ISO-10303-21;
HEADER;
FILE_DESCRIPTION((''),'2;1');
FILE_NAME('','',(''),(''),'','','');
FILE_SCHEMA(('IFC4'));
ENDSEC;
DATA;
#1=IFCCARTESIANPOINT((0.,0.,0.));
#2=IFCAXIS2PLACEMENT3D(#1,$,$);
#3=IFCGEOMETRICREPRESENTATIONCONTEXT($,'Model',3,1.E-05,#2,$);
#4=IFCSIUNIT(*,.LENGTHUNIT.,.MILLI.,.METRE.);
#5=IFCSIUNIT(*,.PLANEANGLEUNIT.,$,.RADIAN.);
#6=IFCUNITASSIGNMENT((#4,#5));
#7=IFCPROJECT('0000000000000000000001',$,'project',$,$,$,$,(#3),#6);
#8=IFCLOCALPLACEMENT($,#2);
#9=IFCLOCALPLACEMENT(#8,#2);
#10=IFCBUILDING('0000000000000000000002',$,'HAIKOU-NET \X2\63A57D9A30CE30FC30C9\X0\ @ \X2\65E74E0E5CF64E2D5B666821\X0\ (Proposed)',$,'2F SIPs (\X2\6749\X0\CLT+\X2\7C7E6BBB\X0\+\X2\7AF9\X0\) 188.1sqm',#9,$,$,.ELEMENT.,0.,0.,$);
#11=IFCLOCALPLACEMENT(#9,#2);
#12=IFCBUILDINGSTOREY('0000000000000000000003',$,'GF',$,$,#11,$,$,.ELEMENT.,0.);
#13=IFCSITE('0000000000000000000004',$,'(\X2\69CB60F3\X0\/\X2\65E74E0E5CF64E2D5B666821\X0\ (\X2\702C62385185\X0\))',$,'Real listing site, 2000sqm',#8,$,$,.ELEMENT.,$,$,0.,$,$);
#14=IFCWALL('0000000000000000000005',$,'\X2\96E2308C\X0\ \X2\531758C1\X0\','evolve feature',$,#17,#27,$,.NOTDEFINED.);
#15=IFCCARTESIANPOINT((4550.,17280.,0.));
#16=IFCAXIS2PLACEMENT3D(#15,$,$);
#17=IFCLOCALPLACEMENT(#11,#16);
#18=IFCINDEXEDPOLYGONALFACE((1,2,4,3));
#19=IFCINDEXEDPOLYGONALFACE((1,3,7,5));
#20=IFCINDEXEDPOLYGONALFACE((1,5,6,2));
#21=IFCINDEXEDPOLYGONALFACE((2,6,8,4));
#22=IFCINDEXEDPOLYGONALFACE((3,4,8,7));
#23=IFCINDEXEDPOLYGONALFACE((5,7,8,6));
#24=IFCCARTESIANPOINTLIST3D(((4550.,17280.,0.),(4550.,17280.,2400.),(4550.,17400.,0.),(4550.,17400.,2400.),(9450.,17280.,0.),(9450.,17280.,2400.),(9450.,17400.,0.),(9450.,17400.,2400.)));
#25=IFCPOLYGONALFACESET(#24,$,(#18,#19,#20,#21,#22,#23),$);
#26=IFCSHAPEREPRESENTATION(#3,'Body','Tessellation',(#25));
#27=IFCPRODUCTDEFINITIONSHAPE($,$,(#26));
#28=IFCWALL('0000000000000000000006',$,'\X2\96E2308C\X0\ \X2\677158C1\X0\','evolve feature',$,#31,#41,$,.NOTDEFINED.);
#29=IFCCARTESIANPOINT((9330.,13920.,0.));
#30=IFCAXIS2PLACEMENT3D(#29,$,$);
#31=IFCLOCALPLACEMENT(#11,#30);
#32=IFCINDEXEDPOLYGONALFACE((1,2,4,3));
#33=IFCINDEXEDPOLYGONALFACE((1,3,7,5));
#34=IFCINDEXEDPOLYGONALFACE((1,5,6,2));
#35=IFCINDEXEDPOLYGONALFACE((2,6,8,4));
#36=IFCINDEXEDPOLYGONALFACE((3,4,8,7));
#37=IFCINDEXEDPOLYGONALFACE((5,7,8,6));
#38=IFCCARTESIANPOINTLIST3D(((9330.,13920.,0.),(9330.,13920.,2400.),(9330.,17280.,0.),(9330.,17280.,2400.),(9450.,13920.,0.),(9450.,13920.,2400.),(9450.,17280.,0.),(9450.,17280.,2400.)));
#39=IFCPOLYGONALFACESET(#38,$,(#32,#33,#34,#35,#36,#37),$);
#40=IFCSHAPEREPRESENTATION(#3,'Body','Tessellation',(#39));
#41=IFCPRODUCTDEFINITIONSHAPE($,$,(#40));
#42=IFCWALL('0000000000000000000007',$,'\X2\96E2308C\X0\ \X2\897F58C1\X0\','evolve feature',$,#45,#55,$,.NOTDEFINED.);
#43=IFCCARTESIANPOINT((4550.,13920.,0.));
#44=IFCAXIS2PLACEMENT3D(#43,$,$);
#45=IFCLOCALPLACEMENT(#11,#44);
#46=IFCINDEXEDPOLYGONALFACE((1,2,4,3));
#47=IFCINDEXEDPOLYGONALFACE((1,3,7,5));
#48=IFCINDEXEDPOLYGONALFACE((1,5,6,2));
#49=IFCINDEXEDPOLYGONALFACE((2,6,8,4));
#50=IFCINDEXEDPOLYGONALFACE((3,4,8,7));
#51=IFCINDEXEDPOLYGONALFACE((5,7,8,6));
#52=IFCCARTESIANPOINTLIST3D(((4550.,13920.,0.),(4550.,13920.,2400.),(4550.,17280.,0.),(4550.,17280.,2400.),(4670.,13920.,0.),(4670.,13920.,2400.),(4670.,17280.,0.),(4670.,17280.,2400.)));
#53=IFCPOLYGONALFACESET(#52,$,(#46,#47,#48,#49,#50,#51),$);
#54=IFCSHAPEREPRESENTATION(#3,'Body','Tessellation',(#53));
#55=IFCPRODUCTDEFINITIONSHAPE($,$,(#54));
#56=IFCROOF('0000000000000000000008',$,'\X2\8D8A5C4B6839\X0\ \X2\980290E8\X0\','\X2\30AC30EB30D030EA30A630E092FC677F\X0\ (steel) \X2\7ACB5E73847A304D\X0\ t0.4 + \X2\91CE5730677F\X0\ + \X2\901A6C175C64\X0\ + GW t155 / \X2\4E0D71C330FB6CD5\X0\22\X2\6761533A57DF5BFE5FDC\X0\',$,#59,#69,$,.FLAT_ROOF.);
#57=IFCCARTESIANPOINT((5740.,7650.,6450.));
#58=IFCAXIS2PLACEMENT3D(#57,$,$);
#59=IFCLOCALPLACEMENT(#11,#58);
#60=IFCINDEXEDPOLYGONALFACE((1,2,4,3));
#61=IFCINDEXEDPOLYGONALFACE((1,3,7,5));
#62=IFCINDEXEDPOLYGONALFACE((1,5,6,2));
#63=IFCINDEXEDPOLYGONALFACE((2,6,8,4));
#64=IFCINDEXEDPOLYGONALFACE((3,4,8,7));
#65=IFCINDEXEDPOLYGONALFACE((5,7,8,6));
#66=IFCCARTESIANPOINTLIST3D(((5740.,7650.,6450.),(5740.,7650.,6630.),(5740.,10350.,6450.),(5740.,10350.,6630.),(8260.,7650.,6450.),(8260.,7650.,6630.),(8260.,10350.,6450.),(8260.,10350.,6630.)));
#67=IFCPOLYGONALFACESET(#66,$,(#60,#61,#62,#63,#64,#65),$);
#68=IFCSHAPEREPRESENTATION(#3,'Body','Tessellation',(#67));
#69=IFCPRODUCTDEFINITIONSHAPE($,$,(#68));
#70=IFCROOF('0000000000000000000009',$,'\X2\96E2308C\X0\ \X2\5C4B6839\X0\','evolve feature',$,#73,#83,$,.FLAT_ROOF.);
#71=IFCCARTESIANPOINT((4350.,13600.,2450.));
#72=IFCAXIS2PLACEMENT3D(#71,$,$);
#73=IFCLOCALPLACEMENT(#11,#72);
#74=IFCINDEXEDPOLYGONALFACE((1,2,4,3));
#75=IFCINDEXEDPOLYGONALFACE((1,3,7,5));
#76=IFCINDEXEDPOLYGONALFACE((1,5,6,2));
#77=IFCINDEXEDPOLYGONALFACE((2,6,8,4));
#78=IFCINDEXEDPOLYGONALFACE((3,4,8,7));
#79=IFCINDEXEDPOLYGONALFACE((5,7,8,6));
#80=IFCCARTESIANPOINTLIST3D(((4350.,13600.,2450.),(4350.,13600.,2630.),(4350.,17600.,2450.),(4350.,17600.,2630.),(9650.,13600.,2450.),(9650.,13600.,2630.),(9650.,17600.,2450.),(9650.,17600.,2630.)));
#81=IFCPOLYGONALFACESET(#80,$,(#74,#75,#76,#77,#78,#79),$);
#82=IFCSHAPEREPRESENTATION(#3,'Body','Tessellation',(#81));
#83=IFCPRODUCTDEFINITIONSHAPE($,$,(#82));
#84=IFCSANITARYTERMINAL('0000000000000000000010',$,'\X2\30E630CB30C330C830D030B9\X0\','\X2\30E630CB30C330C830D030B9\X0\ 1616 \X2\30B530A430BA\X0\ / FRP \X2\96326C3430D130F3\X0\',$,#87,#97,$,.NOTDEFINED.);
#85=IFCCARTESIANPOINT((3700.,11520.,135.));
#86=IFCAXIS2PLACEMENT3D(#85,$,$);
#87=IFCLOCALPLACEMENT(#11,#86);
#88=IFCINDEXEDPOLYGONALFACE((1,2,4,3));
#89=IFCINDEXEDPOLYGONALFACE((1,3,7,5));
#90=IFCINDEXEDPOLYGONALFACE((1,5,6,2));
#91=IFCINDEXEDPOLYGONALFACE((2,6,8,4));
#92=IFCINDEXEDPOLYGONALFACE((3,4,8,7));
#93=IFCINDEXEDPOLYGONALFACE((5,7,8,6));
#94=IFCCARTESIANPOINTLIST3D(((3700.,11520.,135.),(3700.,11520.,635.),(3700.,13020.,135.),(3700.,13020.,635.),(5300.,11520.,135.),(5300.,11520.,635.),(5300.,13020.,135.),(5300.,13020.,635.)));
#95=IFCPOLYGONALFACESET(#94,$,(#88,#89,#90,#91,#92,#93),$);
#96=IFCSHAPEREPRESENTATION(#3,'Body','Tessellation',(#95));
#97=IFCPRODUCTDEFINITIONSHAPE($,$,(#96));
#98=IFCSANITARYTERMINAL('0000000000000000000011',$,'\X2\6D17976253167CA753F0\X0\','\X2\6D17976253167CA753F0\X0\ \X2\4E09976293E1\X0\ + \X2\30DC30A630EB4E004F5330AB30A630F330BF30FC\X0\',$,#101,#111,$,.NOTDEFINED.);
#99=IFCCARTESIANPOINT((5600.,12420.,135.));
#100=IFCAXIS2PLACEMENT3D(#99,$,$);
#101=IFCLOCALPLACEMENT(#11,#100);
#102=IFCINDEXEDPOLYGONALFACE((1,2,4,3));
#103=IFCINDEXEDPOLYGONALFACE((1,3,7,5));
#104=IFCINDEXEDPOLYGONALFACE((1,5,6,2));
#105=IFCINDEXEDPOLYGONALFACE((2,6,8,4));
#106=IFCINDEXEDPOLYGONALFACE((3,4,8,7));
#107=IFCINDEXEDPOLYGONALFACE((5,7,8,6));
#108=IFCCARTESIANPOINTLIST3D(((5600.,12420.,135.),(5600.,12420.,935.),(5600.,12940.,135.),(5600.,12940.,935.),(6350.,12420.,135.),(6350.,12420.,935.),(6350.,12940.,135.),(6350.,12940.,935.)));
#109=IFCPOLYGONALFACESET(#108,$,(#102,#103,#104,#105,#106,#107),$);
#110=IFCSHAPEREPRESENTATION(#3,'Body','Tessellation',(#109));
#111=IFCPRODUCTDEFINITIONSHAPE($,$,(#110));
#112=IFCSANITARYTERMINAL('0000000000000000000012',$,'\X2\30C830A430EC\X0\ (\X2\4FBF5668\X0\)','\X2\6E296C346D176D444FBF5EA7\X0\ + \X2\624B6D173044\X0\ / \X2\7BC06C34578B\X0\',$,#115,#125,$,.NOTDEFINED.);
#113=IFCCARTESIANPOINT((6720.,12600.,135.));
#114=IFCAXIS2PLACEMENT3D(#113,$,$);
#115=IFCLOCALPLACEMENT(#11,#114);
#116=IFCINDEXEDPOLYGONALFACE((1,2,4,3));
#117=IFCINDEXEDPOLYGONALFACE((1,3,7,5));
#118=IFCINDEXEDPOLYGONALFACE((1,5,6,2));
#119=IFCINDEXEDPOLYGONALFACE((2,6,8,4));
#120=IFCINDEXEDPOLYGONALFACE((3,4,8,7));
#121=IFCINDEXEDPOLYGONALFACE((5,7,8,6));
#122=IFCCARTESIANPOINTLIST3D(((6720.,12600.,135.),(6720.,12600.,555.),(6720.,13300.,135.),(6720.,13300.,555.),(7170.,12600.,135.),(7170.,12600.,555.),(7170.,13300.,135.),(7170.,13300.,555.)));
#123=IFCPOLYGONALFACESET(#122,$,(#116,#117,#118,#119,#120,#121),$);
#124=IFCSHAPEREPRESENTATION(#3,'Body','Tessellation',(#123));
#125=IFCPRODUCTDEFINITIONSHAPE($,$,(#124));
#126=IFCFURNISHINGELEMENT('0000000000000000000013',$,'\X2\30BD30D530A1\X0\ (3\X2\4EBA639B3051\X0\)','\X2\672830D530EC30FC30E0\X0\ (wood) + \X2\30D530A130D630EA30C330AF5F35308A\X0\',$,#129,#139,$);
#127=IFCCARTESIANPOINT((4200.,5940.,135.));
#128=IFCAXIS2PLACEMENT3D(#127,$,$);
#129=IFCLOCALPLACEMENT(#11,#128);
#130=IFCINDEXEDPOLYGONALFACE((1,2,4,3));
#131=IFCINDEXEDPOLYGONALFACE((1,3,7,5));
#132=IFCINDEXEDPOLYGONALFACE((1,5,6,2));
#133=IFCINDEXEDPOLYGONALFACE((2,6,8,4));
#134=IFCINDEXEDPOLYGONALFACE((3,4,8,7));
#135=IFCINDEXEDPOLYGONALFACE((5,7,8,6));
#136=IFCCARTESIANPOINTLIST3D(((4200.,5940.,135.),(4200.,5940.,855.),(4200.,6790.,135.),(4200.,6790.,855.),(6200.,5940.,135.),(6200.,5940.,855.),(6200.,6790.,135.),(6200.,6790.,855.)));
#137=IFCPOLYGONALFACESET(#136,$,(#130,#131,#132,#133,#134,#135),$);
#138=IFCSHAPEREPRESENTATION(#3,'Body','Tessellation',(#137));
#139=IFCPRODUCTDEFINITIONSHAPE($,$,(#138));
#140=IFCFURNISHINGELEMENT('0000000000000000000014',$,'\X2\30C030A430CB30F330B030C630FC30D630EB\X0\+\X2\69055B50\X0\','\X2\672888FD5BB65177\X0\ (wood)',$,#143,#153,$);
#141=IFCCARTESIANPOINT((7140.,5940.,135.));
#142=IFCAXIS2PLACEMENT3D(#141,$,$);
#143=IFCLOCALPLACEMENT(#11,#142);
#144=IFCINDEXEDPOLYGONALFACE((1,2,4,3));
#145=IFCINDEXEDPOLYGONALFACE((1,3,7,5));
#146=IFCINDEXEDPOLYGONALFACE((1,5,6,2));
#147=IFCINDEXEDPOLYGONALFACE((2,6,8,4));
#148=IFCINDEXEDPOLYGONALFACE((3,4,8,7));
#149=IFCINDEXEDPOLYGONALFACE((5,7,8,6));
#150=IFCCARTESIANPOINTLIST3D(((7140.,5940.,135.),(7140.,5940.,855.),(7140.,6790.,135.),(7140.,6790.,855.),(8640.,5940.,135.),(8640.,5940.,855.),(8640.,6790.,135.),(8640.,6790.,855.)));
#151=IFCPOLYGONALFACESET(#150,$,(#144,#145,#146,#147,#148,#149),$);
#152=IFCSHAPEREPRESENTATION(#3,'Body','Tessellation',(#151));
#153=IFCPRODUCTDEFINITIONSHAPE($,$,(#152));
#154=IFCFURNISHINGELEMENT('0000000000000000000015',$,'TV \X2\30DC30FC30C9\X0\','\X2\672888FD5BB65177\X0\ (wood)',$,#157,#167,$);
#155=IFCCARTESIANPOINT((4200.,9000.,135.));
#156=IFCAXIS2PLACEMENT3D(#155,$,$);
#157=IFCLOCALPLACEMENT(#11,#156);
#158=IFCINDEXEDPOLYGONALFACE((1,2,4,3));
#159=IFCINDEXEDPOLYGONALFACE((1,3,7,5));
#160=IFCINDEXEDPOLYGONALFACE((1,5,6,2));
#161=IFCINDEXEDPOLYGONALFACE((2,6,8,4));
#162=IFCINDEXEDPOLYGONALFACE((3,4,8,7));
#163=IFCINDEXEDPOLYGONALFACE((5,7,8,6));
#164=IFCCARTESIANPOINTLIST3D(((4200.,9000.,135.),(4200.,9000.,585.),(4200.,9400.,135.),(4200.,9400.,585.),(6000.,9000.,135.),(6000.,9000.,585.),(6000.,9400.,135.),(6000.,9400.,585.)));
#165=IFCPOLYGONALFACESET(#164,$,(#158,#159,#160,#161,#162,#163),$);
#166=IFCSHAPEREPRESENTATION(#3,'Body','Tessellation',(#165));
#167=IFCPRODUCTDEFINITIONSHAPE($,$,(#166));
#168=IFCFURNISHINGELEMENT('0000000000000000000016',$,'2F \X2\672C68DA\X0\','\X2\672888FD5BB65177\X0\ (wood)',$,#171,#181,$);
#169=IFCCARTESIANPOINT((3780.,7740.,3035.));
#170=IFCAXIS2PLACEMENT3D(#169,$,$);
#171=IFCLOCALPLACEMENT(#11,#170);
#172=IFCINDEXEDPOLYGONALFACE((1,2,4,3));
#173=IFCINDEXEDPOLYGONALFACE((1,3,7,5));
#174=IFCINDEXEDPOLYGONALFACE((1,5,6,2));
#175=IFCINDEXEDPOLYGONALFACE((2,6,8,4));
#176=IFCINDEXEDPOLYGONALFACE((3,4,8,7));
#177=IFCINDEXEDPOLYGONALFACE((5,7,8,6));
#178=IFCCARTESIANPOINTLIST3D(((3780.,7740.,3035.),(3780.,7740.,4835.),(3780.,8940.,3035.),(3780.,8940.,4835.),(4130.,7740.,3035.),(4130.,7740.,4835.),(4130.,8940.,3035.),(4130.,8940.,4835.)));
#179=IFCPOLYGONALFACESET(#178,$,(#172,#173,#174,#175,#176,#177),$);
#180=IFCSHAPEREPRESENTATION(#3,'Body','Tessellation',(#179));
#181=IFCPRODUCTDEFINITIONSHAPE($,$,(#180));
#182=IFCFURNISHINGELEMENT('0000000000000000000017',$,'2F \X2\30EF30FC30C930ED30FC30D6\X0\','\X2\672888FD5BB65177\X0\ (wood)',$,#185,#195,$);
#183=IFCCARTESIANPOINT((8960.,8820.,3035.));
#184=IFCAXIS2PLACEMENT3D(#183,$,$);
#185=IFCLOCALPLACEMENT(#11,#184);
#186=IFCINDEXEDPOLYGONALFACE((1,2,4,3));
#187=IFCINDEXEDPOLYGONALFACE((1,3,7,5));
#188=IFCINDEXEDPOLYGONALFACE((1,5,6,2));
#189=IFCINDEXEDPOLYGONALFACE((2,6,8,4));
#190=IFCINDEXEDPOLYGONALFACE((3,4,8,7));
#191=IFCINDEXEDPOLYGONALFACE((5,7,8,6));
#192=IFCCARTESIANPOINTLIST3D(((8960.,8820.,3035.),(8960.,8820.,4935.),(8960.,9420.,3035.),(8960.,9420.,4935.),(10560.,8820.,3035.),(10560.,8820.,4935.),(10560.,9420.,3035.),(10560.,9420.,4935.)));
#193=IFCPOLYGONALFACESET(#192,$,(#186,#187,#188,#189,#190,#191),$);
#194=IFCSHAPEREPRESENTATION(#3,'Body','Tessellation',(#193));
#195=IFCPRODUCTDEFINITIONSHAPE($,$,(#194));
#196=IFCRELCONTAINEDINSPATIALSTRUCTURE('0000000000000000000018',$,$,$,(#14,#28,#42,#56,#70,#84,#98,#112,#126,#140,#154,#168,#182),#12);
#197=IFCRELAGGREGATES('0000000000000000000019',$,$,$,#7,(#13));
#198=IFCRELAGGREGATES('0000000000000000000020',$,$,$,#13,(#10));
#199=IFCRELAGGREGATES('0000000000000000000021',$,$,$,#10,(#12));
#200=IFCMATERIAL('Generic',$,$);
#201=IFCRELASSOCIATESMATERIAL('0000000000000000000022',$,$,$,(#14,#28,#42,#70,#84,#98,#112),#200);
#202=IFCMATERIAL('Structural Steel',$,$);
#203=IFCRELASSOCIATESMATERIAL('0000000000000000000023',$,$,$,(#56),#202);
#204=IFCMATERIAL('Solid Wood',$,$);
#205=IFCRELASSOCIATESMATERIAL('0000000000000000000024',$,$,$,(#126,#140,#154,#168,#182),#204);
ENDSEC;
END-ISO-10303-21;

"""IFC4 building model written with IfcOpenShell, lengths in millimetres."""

from ifc_helpers import new_model, si_unit, frame, frame_2d, origin, place, context, project, spatial, rectangle, extrude, material, element, save


model = new_model("IFC4")

# Units and contexts
model_context = context("Model", 3, precision=1e-05, world=origin())
ifc_project = project(units=[si_unit("LENGTHUNIT", "METRE", prefix="MILLI"), si_unit("PLANEANGLEUNIT", "RADIAN")], contexts=[model_context])

# Site, building, storey
site_placement = place(None, origin())
site = spatial("IfcSite", under=ifc_project, at=site_placement, Name="(構想/旧与島中学校 (瀬戸内))", ObjectType="Real listing site, 2000sqm", CompositionType="ELEMENT", RefElevation=0.0)
building_placement = place(site_placement, origin())
building = spatial("IfcBuilding", under=site, at=building_placement, Name="HAIKOU-NET 接続ノード @ 旧与島中学校 (Proposed)", ObjectType="2F SIPs (杉CLT+籾殻+竹) 188.1sqm", CompositionType="ELEMENT", ElevationOfRefHeight=0.0, ElevationOfTerrain=0.0)
storey_placement = place(building_placement, origin())
storey = spatial("IfcBuildingStorey", under=building, at=storey_placement, Name="GF", CompositionType="ELEMENT", Elevation=0.0)

# Shared definitions
ifc_material_1 = material(Name="Generic")

# Shared definitions
ifc_material_2 = material(Name="Solid Wood")

# Walls
wall_1_placement = place(storey_placement, frame((4550.0, 17280.0, 0.0)))
element("IfcWall", 1, at=wall_1_placement, inside=storey, material=ifc_material_1, Name="離れ 北壁", Description="evolve feature", PredefinedType="NOTDEFINED", context=model_context, shape_type="SweptSolid", body=[
    extrude(rectangle(XDim=4900.0, YDim=120.0, at=frame_2d((2450.0, 60.0))), frame((4550.0, 17280.0, 0.0)), (0.0, 0.0, 1.0), 2400.0),
])
wall_2_placement = place(storey_placement, frame((9330.0, 13920.0, 0.0)))
element("IfcWall", 2, at=wall_2_placement, inside=storey, material=ifc_material_1, Name="離れ 東壁", Description="evolve feature", PredefinedType="NOTDEFINED", context=model_context, shape_type="SweptSolid", body=[
    extrude(rectangle(XDim=120.0, YDim=3360.0, at=frame_2d((60.0, 1680.0))), frame((9330.0, 13920.0, 0.0)), (0.0, 0.0, 1.0), 2400.0),
])
wall_3_placement = place(storey_placement, frame((4550.0, 13920.0, 0.0)))
element("IfcWall", 3, at=wall_3_placement, inside=storey, material=ifc_material_1, Name="離れ 西壁", Description="evolve feature", PredefinedType="NOTDEFINED", context=model_context, shape_type="SweptSolid", body=[
    extrude(rectangle(XDim=120.0, YDim=3360.0, at=frame_2d((60.0, 1680.0))), frame((4550.0, 13920.0, 0.0)), (0.0, 0.0, 1.0), 2400.0),
])

# Roofs
ifc_material_3 = material(Name="Structural Steel")
roof_1_placement = place(storey_placement, frame((5740.0, 7650.0, 6450.0)))
element("IfcRoof", 4, at=roof_1_placement, inside=storey, material=ifc_material_3, Name="越屋根 頂部", Description="ガルバリウム鋼板 (steel) 立平葺き t0.4 + 野地板 + 通気層 + GW t155 / 不燃・法22条区域対応", PredefinedType="FLAT_ROOF", context=model_context, shape_type="SweptSolid", body=[
    extrude(rectangle(XDim=2520.0, YDim=2700.0, at=frame_2d((1260.0, 1350.0))), frame((5740.0, 7650.0, 6450.0)), (0.0, 0.0, 1.0), 180.0),
])
roof_2_placement = place(storey_placement, frame((4350.0, 13600.0, 2450.0)))
element("IfcRoof", 5, at=roof_2_placement, inside=storey, material=ifc_material_1, Name="離れ 屋根", Description="evolve feature", PredefinedType="FLAT_ROOF", context=model_context, shape_type="SweptSolid", body=[
    extrude(rectangle(XDim=5300.0, YDim=4000.0, at=frame_2d((2650.0, 2000.0))), frame((4350.0, 13600.0, 2450.0)), (0.0, 0.0, 1.0), 180.0),
])

# Sanitary terminals
sanitary_terminal_1_placement = place(storey_placement, frame((3700.0, 11520.0, 135.0)))
element("IfcSanitaryTerminal", 6, at=sanitary_terminal_1_placement, inside=storey, material=ifc_material_1, Name="ユニットバス", Description="ユニットバス 1616 サイズ / FRP 防水パン", PredefinedType="NOTDEFINED", context=model_context, shape_type="SweptSolid", body=[
    extrude(rectangle(XDim=1600.0, YDim=1500.0, at=frame_2d((800.0, 750.0))), frame((3700.0, 11520.0, 135.0)), (0.0, 0.0, 1.0), 500.0),
])
sanitary_terminal_2_placement = place(storey_placement, frame((5600.0, 12420.0, 135.0)))
element("IfcSanitaryTerminal", 7, at=sanitary_terminal_2_placement, inside=storey, material=ifc_material_1, Name="洗面化粧台", Description="洗面化粧台 三面鏡 + ボウル一体カウンター", PredefinedType="NOTDEFINED", context=model_context, shape_type="SweptSolid", body=[
    extrude(rectangle(XDim=750.0, YDim=520.0, at=frame_2d((375.0, 260.0))), frame((5600.0, 12420.0, 135.0)), (0.0, 0.0, 1.0), 800.0),
])
sanitary_terminal_3_placement = place(storey_placement, frame((6720.0, 12600.0, 135.0)))
element("IfcSanitaryTerminal", 8, at=sanitary_terminal_3_placement, inside=storey, material=ifc_material_1, Name="トイレ (便器)", Description="温水洗浄便座 + 手洗い / 節水型", PredefinedType="NOTDEFINED", context=model_context, shape_type="SweptSolid", body=[
    extrude(rectangle(XDim=450.0, YDim=700.0, at=frame_2d((225.0, 350.0))), frame((6720.0, 12600.0, 135.0)), (0.0, 0.0, 1.0), 420.0),
])

# Furnishing elements
furnishing_1_placement = place(storey_placement, frame((4200.0, 5940.0, 135.0)))
element("IfcFurnishingElement", 9, at=furnishing_1_placement, inside=storey, material=ifc_material_2, Name="ソファ (3人掛け)", Description="木フレーム (wood) + ファブリック張り", context=model_context, shape_type="SweptSolid", body=[
    extrude(rectangle(XDim=2000.0, YDim=850.0, at=frame_2d((1000.0, 425.0))), frame((4200.0, 5940.0, 135.0)), (0.0, 0.0, 1.0), 720.0),
])
furnishing_2_placement = place(storey_placement, frame((7140.0, 5940.0, 135.0)))
element("IfcFurnishingElement", 10, at=furnishing_2_placement, inside=storey, material=ifc_material_2, Name="ダイニングテーブル+椅子", Description="木製家具 (wood)", context=model_context, shape_type="SweptSolid", body=[
    extrude(rectangle(XDim=1500.0, YDim=850.0, at=frame_2d((750.0, 425.0))), frame((7140.0, 5940.0, 135.0)), (0.0, 0.0, 1.0), 720.0),
])
furnishing_3_placement = place(storey_placement, frame((4200.0, 9000.0, 135.0)))
element("IfcFurnishingElement", 11, at=furnishing_3_placement, inside=storey, material=ifc_material_2, Name="TV ボード", Description="木製家具 (wood)", context=model_context, shape_type="SweptSolid", body=[
    extrude(rectangle(XDim=1800.0, YDim=400.0, at=frame_2d((900.0, 200.0))), frame((4200.0, 9000.0, 135.0)), (0.0, 0.0, 1.0), 450.0),
])
furnishing_4_placement = place(storey_placement, frame((3780.0, 7740.0, 3035.0)))
element("IfcFurnishingElement", 12, at=furnishing_4_placement, inside=storey, material=ifc_material_2, Name="2F 本棚", Description="木製家具 (wood)", context=model_context, shape_type="SweptSolid", body=[
    extrude(rectangle(XDim=350.0, YDim=1200.0, at=frame_2d((175.0, 600.0))), frame((3780.0, 7740.0, 3035.0)), (0.0, 0.0, 1.0), 1800.0),
])
furnishing_5_placement = place(storey_placement, frame((8960.0, 8820.0, 3035.0)))
element("IfcFurnishingElement", 13, at=furnishing_5_placement, inside=storey, material=ifc_material_2, Name="2F ワードローブ", Description="木製家具 (wood)", context=model_context, shape_type="SweptSolid", body=[
    extrude(rectangle(XDim=1600.0, YDim=600.0, at=frame_2d((800.0, 300.0))), frame((8960.0, 8820.0, 3035.0)), (0.0, 0.0, 1.0), 1900.0),
])

save(model, "model.ifc")
